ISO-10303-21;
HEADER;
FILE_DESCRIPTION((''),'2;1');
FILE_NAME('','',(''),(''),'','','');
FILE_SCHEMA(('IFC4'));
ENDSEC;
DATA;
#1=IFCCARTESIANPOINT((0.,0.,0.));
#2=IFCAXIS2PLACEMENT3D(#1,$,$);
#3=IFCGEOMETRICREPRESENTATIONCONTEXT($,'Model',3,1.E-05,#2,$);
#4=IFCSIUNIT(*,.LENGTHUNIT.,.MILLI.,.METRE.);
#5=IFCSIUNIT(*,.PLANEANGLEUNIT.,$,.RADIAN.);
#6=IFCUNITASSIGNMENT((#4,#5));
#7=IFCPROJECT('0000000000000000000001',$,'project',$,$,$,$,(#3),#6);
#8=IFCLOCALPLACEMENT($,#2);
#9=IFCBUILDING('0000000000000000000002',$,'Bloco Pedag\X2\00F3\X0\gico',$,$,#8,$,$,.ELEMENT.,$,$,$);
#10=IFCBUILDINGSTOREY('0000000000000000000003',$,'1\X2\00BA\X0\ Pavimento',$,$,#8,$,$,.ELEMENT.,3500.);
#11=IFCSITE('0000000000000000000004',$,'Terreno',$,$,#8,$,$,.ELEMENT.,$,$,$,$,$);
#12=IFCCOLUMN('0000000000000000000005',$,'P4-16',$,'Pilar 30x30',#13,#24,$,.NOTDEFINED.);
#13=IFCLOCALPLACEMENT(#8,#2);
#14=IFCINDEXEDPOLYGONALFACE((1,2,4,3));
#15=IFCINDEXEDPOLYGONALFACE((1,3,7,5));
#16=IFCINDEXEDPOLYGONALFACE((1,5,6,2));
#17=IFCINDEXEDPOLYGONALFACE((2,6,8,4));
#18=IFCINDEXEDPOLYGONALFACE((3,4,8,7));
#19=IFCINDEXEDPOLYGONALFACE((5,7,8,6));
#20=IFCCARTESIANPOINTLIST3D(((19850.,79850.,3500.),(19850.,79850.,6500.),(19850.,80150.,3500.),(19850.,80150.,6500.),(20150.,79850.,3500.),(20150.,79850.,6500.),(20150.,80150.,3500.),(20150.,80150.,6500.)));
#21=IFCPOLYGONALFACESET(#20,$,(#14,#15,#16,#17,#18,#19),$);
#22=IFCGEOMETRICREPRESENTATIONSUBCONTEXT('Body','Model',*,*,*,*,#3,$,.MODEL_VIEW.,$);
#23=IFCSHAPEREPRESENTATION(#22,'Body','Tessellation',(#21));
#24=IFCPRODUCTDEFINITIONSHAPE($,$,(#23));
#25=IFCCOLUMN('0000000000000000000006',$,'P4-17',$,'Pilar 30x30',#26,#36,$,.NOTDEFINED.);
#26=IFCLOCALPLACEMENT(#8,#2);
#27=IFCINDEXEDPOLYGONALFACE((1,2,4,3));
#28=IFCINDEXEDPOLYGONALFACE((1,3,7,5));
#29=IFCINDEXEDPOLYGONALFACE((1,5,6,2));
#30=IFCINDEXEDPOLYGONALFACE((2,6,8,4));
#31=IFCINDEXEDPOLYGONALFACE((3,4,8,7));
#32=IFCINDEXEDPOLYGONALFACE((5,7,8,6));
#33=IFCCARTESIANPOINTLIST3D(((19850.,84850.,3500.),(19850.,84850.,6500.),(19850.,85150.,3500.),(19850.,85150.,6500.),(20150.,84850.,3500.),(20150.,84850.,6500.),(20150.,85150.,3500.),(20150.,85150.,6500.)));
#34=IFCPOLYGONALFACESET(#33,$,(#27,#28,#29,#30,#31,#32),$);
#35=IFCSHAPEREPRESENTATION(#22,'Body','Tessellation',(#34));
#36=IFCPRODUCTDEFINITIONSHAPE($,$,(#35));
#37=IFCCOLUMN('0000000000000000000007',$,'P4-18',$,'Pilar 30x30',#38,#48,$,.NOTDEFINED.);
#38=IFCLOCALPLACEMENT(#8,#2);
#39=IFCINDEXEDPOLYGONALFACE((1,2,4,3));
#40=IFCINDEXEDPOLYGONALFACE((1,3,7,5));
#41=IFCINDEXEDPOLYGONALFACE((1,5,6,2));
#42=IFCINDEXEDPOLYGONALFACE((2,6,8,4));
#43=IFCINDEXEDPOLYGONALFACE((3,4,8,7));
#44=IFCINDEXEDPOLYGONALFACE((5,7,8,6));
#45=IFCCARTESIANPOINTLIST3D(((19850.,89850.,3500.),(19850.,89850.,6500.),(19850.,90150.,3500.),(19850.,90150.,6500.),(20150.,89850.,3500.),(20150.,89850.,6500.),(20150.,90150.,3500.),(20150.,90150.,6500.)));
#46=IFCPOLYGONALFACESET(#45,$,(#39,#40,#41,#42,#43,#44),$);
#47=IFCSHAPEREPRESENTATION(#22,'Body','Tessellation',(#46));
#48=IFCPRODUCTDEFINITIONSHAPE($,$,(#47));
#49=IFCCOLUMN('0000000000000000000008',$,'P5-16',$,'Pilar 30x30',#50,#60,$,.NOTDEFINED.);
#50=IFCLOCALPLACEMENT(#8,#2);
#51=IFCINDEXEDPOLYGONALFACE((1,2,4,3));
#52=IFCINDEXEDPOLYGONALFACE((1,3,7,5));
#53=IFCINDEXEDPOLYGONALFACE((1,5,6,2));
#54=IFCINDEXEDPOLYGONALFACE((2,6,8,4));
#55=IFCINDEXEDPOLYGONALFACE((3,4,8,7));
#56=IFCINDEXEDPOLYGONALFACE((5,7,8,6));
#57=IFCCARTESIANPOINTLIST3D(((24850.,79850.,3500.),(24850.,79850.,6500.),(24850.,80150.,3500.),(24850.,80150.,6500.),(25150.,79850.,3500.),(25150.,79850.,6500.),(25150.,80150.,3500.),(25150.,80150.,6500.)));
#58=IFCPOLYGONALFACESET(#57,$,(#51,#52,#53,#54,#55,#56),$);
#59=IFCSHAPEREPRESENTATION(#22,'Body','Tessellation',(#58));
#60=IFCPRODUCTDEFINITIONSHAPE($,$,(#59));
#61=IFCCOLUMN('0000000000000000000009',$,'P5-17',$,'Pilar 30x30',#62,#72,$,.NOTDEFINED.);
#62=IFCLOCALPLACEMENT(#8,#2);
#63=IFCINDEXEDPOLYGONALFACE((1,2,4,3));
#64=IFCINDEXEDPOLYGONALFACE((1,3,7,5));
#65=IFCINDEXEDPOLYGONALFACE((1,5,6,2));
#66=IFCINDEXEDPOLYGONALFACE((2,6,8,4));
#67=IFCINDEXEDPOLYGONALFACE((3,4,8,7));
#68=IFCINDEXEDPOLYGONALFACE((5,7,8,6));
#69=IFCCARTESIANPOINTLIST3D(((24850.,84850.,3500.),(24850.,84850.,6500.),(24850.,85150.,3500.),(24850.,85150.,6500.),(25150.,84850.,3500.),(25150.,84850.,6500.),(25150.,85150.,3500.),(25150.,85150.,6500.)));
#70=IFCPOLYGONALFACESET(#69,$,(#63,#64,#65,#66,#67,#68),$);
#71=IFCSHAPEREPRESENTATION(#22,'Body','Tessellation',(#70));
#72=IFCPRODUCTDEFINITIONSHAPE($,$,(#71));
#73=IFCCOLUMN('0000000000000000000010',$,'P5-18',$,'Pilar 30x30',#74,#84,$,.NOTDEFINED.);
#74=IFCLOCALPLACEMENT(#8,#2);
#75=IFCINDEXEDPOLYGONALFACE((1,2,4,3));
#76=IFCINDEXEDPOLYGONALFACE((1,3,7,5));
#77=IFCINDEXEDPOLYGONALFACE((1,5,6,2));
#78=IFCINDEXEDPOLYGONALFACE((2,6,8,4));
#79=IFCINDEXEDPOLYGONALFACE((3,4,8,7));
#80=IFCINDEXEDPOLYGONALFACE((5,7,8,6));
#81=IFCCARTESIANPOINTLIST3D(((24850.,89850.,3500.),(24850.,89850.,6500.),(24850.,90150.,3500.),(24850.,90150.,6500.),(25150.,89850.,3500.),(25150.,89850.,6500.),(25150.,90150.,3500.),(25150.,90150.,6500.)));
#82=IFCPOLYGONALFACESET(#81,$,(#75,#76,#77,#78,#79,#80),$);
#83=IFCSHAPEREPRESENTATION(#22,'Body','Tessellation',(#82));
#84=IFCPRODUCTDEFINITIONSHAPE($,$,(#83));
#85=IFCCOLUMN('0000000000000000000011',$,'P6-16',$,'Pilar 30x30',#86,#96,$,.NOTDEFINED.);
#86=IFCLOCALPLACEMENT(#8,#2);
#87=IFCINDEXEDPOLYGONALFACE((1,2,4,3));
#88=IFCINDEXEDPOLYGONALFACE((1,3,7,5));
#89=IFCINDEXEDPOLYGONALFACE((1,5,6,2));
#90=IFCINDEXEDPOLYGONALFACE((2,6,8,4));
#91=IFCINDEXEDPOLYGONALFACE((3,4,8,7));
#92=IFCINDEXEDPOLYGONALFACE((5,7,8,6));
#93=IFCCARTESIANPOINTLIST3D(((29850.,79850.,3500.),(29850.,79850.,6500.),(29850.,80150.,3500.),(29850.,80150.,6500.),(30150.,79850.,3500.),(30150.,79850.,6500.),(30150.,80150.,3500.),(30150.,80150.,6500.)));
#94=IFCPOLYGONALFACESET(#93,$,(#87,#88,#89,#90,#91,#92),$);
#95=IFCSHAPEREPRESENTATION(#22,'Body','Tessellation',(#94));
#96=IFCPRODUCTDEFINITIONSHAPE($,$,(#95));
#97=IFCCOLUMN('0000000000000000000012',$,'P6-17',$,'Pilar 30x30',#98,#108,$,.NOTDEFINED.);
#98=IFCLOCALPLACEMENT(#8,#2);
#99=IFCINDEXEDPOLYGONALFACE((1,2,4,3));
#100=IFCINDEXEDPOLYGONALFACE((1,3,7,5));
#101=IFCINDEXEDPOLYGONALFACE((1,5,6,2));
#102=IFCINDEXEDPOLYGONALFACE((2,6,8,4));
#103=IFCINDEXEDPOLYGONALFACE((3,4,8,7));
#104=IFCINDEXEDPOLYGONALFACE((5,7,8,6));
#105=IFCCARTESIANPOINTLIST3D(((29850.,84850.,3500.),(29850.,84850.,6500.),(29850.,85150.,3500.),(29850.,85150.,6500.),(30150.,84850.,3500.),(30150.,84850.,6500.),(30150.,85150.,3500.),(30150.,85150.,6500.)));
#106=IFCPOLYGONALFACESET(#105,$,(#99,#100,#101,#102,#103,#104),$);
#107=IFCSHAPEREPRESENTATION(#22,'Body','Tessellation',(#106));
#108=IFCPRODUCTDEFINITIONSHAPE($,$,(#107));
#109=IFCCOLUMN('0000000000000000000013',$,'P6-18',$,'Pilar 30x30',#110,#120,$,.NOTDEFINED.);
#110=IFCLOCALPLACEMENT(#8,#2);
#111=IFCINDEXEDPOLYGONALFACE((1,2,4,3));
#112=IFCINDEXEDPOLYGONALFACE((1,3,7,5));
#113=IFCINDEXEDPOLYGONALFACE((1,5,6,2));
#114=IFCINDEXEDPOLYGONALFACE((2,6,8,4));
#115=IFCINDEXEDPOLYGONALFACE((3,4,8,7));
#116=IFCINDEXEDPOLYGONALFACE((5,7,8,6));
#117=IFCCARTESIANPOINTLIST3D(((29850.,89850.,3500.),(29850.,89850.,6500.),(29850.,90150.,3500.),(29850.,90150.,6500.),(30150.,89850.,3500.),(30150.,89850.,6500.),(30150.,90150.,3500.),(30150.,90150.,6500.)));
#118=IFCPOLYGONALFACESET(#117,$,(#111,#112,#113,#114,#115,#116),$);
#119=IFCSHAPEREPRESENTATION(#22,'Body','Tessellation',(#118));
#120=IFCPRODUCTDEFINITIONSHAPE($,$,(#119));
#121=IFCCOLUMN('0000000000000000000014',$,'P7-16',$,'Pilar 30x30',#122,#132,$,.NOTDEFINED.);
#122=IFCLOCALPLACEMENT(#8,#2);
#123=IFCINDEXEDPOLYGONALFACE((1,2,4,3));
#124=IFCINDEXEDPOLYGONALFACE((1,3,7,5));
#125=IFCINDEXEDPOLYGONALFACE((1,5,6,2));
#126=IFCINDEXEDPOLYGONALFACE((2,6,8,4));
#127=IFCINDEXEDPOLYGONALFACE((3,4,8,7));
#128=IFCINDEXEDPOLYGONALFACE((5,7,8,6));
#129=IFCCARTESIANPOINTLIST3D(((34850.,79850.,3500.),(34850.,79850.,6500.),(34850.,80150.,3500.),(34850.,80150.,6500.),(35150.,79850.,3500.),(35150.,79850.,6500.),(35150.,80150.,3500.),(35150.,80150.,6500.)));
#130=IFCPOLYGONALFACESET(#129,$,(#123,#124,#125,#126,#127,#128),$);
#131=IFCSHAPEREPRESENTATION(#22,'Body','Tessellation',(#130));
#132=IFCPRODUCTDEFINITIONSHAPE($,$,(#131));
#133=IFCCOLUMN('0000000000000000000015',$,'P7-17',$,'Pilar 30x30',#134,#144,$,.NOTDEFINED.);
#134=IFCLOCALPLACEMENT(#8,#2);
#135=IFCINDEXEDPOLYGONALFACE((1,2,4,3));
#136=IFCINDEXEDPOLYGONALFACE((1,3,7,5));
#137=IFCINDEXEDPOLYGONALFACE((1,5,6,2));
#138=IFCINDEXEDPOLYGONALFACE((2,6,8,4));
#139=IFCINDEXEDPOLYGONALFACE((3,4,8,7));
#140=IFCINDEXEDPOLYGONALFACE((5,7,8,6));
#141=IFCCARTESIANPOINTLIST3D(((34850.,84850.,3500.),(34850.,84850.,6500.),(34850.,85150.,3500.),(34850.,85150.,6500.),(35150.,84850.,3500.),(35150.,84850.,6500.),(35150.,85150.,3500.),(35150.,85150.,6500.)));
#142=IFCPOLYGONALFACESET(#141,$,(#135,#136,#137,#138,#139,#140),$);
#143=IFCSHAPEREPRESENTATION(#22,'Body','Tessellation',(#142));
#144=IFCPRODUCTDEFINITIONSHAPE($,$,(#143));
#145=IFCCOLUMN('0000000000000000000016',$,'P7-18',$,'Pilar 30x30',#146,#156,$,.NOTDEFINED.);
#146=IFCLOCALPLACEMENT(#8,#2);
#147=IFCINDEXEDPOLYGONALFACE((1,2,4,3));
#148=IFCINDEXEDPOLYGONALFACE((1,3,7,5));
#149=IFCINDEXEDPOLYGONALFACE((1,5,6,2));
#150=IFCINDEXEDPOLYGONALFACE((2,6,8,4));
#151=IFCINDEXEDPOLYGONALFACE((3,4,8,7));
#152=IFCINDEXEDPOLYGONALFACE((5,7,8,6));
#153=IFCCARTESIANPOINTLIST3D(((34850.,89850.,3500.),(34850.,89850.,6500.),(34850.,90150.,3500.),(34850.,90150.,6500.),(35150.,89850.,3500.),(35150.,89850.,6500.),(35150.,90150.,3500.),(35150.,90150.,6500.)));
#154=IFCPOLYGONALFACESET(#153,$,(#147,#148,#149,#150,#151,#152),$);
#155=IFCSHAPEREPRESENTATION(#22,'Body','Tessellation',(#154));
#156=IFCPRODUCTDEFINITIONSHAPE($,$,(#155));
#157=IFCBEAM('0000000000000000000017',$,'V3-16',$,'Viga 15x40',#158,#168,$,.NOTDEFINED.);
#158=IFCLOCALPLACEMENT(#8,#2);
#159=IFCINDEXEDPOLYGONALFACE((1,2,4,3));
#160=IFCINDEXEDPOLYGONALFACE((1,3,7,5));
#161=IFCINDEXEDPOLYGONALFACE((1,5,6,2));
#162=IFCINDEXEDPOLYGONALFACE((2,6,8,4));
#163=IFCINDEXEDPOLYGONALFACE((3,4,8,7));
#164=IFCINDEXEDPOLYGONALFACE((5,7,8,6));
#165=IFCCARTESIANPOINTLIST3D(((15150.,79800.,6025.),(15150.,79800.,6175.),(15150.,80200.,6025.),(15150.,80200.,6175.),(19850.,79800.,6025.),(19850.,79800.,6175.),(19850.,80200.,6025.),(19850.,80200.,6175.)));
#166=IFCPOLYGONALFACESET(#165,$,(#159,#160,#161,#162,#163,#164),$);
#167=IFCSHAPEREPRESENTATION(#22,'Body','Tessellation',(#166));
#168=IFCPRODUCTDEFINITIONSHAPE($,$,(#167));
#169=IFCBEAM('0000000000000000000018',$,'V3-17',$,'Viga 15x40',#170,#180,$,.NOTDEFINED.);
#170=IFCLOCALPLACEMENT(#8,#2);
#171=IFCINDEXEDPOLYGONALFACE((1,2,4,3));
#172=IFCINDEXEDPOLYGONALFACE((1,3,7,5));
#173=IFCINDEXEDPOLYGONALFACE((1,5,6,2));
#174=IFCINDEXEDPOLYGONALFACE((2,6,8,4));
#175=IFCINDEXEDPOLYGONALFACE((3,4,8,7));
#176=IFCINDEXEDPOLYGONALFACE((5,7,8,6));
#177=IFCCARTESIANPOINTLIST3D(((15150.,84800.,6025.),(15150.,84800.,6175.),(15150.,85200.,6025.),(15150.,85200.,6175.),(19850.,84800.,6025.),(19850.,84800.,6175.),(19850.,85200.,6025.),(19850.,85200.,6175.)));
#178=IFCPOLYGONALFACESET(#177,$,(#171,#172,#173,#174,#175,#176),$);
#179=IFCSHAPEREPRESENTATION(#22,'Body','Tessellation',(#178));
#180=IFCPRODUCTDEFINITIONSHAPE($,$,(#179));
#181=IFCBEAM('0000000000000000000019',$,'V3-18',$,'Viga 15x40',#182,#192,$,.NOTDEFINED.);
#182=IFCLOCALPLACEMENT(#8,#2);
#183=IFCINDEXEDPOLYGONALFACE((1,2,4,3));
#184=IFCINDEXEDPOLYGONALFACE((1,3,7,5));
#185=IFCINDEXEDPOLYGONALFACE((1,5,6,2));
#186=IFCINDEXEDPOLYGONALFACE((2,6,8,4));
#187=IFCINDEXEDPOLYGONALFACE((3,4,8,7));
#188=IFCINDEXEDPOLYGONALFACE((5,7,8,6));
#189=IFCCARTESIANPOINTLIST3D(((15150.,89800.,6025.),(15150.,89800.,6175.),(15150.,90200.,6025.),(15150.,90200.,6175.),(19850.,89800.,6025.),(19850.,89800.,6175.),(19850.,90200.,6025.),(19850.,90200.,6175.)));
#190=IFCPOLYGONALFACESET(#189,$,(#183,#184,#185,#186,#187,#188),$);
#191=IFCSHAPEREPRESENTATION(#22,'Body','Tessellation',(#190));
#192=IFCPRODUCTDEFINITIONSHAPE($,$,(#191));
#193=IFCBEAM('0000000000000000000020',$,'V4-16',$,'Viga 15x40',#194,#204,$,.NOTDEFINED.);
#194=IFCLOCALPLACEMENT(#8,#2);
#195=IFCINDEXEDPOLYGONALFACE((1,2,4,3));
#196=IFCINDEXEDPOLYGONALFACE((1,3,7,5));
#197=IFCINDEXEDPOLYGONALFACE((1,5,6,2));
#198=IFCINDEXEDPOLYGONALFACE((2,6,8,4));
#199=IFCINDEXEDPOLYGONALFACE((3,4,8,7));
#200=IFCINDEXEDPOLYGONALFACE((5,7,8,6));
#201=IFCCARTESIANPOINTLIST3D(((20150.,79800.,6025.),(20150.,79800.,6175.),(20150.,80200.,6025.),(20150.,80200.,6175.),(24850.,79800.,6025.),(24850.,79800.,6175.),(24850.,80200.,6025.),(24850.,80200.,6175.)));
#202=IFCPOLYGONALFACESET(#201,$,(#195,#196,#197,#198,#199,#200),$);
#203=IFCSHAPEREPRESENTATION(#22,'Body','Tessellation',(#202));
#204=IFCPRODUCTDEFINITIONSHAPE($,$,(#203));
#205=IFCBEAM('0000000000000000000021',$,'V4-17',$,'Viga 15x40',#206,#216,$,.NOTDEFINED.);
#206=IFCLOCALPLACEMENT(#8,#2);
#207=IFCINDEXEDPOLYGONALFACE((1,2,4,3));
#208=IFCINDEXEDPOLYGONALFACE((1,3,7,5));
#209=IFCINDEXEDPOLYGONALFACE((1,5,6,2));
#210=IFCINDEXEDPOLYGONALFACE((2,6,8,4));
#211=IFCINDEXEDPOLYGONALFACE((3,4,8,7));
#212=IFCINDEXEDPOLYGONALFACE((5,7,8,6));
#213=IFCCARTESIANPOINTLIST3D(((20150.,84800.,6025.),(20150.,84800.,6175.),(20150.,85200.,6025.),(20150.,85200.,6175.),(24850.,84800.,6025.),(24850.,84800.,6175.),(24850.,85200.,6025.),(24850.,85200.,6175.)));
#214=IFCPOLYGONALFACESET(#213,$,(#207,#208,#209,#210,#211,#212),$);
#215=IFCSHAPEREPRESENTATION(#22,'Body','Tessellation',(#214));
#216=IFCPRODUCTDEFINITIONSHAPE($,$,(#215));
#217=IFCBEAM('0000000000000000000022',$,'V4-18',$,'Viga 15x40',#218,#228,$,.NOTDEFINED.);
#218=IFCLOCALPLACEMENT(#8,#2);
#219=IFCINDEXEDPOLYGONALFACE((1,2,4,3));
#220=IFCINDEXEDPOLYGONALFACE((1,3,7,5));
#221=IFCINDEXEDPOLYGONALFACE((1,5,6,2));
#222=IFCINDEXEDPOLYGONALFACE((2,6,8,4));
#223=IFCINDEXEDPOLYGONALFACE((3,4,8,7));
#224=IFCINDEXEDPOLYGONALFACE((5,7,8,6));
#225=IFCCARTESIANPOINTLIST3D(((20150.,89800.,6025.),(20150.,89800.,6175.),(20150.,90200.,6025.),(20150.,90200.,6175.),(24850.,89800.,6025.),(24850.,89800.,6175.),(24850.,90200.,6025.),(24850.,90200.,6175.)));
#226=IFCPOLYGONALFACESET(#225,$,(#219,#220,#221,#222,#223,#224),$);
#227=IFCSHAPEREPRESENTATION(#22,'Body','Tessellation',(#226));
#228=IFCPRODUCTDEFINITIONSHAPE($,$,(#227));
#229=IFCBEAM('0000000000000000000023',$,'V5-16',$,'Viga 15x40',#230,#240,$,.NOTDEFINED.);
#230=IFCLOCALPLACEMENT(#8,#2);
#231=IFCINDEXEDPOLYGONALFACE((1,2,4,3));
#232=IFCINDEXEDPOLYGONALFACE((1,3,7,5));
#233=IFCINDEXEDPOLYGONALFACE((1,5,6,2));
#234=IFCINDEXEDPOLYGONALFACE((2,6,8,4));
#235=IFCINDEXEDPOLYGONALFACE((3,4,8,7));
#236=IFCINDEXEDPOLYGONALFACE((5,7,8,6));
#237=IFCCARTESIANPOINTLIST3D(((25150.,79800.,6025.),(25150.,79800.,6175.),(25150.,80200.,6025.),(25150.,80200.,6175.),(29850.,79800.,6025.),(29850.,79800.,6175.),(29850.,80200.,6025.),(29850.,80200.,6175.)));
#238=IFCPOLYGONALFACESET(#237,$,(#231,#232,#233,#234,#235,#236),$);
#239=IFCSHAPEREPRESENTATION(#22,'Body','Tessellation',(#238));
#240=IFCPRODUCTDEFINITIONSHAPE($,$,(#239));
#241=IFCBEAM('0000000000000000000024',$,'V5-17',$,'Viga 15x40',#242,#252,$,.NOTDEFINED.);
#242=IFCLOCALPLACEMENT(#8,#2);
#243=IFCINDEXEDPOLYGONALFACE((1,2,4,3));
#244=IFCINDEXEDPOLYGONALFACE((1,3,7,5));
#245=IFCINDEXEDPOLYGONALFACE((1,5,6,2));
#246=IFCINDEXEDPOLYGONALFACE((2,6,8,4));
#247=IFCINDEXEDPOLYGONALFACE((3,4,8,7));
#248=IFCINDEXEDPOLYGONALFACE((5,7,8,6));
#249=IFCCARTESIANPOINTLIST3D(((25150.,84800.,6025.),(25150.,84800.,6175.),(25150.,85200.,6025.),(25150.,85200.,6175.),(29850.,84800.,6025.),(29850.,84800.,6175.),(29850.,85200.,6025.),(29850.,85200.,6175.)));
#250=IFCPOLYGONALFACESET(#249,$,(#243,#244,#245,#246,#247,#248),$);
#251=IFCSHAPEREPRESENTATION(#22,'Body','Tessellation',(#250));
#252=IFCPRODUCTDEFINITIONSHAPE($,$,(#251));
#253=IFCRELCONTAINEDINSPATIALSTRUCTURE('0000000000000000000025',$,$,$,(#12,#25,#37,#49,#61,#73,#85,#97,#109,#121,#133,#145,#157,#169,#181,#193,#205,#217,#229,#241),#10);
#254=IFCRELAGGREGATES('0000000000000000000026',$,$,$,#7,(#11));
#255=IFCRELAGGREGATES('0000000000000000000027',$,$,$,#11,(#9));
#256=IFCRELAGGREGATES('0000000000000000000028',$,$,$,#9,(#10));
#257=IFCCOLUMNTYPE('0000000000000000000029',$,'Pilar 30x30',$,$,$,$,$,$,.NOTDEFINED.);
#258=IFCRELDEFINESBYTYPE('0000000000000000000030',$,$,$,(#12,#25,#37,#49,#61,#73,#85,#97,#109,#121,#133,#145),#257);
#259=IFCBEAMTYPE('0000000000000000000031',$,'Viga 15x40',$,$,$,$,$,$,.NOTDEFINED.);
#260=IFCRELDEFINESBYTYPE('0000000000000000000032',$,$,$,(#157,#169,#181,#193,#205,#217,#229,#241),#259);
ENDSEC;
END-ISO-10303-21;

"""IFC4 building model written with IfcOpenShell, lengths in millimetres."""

from ifc_helpers import new_model, si_unit, frame, origin, origin_2d, place, context, subcontext, project, spatial, rectangle, extrude, type_object, element, save


model = new_model("IFC4")

# Units and contexts
model_context = context("Model", 3, precision=1e-05, world=origin())
body_context = subcontext(model_context, "Body", "Model", "MODEL_VIEW")
ifc_project = project(units=[si_unit("LENGTHUNIT", "METRE", prefix="MILLI"), si_unit("PLANEANGLEUNIT", "RADIAN")], contexts=[model_context])

# Site, building, storey
placement = place(None, origin())
site = spatial("IfcSite", under=ifc_project, at=placement, Name="Terreno", CompositionType="ELEMENT")
building = spatial("IfcBuilding", under=site, at=placement, Name="Bloco Pedagógico", CompositionType="ELEMENT")
storey = spatial("IfcBuildingStorey", under=building, at=placement, Name="1º Pavimento", CompositionType="ELEMENT", Elevation=3500.0)

# Columns
column_type = type_object("IfcColumnType", Name="Pilar 30x30", PredefinedType="NOTDEFINED")
for number, where, z_axis, x_axis, name in (
    (1, (20000.0, 80000.0, 3500.0), (0.0, 0.0, 1.0), (1.0, 0.0, 0.0), "P4-16"),
    (2, (20000.0, 85000.0, 3500.0), (0.0, 0.0, 1.0), (1.0, 0.0, 0.0), "P4-17"),
    (3, (20000.0, 90000.0, 3500.0), (0.0, 0.0, 1.0), (1.0, 0.0, 0.0), "P4-18"),
    (4, (25000.0, 80000.0, 3500.0), (0.0, 0.0, 1.0), (1.0, 0.0, 0.0), "P5-16"),
    (5, (25000.0, 85000.0, 3500.0), (0.0, 0.0, 1.0), (1.0, 0.0, 0.0), "P5-17"),
    (6, (25000.0, 90000.0, 3500.0), (0.0, 0.0, 1.0), (1.0, 0.0, 0.0), "P5-18"),
    (7, (30000.0, 80000.0, 3500.0), (0.0, 0.0, 1.0), (1.0, 0.0, 0.0), "P6-16"),
    (8, (30000.0, 85000.0, 3500.0), (0.0, 0.0, 1.0), (1.0, 0.0, 0.0), "P6-17"),
    (9, (30000.0, 90000.0, 3500.0), (0.0, 0.0, 1.0), (1.0, 0.0, 0.0), "P6-18"),
    (10, (35000.0, 80000.0, 3500.0), (0.0, 0.0, 1.0), (1.0, 0.0, 0.0), "P7-16"),
    (11, (35000.0, 85000.0, 3500.0), (0.0, 0.0, 1.0), (1.0, 0.0, 0.0), "P7-17"),
    (12, (35000.0, 90000.0, 3500.0), (0.0, 0.0, 1.0), (1.0, 0.0, 0.0), "P7-18"),
):
    element("IfcColumn", number, at=place(None, frame(where, z_axis=z_axis, x_axis=x_axis)), inside=storey, type_object=column_type, Name=name, ObjectType="Pilar 30x30", PredefinedType="NOTDEFINED", context=body_context, shape_type="SweptSolid", body=[
        extrude(rectangle(XDim=300.0, YDim=300.0, at=origin_2d()), None, (0.0, 0.0, 1.0), 3000.0),
    ])

# Beams
beam_type = type_object("IfcBeamType", Name="Viga 15x40", PredefinedType="NOTDEFINED")
for number, where, z_axis, x_axis, name in (
    (13, (15150.0, 80000.0, 6100.0), (1.0, 0.0, 0.0), (0.0, 1.0, 0.0), "V3-16"),
    (14, (15150.0, 85000.0, 6100.0), (1.0, 0.0, 0.0), (0.0, 1.0, 0.0), "V3-17"),
    (15, (15150.0, 90000.0, 6100.0), (1.0, 0.0, 0.0), (0.0, 1.0, 0.0), "V3-18"),
    (16, (20150.0, 80000.0, 6100.0), (1.0, 0.0, 0.0), (0.0, 1.0, 0.0), "V4-16"),
    (17, (20150.0, 85000.0, 6100.0), (1.0, 0.0, 0.0), (0.0, 1.0, 0.0), "V4-17"),
    (18, (20150.0, 90000.0, 6100.0), (1.0, 0.0, 0.0), (0.0, 1.0, 0.0), "V4-18"),
    (19, (25150.0, 80000.0, 6100.0), (1.0, 0.0, 0.0), (0.0, 1.0, 0.0), "V5-16"),
    (20, (25150.0, 85000.0, 6100.0), (1.0, 0.0, 0.0), (0.0, 1.0, 0.0), "V5-17"),
):
    element("IfcBeam", number, at=place(None, frame(where, z_axis=z_axis, x_axis=x_axis)), inside=storey, type_object=beam_type, Name=name, ObjectType="Viga 15x40", PredefinedType="NOTDEFINED", context=body_context, shape_type="SweptSolid", body=[
        extrude(rectangle(XDim=400.0, YDim=150.0, at=origin_2d()), None, (0.0, 0.0, 1.0), 4700.0),
    ])

save(model, "model.ifc")
